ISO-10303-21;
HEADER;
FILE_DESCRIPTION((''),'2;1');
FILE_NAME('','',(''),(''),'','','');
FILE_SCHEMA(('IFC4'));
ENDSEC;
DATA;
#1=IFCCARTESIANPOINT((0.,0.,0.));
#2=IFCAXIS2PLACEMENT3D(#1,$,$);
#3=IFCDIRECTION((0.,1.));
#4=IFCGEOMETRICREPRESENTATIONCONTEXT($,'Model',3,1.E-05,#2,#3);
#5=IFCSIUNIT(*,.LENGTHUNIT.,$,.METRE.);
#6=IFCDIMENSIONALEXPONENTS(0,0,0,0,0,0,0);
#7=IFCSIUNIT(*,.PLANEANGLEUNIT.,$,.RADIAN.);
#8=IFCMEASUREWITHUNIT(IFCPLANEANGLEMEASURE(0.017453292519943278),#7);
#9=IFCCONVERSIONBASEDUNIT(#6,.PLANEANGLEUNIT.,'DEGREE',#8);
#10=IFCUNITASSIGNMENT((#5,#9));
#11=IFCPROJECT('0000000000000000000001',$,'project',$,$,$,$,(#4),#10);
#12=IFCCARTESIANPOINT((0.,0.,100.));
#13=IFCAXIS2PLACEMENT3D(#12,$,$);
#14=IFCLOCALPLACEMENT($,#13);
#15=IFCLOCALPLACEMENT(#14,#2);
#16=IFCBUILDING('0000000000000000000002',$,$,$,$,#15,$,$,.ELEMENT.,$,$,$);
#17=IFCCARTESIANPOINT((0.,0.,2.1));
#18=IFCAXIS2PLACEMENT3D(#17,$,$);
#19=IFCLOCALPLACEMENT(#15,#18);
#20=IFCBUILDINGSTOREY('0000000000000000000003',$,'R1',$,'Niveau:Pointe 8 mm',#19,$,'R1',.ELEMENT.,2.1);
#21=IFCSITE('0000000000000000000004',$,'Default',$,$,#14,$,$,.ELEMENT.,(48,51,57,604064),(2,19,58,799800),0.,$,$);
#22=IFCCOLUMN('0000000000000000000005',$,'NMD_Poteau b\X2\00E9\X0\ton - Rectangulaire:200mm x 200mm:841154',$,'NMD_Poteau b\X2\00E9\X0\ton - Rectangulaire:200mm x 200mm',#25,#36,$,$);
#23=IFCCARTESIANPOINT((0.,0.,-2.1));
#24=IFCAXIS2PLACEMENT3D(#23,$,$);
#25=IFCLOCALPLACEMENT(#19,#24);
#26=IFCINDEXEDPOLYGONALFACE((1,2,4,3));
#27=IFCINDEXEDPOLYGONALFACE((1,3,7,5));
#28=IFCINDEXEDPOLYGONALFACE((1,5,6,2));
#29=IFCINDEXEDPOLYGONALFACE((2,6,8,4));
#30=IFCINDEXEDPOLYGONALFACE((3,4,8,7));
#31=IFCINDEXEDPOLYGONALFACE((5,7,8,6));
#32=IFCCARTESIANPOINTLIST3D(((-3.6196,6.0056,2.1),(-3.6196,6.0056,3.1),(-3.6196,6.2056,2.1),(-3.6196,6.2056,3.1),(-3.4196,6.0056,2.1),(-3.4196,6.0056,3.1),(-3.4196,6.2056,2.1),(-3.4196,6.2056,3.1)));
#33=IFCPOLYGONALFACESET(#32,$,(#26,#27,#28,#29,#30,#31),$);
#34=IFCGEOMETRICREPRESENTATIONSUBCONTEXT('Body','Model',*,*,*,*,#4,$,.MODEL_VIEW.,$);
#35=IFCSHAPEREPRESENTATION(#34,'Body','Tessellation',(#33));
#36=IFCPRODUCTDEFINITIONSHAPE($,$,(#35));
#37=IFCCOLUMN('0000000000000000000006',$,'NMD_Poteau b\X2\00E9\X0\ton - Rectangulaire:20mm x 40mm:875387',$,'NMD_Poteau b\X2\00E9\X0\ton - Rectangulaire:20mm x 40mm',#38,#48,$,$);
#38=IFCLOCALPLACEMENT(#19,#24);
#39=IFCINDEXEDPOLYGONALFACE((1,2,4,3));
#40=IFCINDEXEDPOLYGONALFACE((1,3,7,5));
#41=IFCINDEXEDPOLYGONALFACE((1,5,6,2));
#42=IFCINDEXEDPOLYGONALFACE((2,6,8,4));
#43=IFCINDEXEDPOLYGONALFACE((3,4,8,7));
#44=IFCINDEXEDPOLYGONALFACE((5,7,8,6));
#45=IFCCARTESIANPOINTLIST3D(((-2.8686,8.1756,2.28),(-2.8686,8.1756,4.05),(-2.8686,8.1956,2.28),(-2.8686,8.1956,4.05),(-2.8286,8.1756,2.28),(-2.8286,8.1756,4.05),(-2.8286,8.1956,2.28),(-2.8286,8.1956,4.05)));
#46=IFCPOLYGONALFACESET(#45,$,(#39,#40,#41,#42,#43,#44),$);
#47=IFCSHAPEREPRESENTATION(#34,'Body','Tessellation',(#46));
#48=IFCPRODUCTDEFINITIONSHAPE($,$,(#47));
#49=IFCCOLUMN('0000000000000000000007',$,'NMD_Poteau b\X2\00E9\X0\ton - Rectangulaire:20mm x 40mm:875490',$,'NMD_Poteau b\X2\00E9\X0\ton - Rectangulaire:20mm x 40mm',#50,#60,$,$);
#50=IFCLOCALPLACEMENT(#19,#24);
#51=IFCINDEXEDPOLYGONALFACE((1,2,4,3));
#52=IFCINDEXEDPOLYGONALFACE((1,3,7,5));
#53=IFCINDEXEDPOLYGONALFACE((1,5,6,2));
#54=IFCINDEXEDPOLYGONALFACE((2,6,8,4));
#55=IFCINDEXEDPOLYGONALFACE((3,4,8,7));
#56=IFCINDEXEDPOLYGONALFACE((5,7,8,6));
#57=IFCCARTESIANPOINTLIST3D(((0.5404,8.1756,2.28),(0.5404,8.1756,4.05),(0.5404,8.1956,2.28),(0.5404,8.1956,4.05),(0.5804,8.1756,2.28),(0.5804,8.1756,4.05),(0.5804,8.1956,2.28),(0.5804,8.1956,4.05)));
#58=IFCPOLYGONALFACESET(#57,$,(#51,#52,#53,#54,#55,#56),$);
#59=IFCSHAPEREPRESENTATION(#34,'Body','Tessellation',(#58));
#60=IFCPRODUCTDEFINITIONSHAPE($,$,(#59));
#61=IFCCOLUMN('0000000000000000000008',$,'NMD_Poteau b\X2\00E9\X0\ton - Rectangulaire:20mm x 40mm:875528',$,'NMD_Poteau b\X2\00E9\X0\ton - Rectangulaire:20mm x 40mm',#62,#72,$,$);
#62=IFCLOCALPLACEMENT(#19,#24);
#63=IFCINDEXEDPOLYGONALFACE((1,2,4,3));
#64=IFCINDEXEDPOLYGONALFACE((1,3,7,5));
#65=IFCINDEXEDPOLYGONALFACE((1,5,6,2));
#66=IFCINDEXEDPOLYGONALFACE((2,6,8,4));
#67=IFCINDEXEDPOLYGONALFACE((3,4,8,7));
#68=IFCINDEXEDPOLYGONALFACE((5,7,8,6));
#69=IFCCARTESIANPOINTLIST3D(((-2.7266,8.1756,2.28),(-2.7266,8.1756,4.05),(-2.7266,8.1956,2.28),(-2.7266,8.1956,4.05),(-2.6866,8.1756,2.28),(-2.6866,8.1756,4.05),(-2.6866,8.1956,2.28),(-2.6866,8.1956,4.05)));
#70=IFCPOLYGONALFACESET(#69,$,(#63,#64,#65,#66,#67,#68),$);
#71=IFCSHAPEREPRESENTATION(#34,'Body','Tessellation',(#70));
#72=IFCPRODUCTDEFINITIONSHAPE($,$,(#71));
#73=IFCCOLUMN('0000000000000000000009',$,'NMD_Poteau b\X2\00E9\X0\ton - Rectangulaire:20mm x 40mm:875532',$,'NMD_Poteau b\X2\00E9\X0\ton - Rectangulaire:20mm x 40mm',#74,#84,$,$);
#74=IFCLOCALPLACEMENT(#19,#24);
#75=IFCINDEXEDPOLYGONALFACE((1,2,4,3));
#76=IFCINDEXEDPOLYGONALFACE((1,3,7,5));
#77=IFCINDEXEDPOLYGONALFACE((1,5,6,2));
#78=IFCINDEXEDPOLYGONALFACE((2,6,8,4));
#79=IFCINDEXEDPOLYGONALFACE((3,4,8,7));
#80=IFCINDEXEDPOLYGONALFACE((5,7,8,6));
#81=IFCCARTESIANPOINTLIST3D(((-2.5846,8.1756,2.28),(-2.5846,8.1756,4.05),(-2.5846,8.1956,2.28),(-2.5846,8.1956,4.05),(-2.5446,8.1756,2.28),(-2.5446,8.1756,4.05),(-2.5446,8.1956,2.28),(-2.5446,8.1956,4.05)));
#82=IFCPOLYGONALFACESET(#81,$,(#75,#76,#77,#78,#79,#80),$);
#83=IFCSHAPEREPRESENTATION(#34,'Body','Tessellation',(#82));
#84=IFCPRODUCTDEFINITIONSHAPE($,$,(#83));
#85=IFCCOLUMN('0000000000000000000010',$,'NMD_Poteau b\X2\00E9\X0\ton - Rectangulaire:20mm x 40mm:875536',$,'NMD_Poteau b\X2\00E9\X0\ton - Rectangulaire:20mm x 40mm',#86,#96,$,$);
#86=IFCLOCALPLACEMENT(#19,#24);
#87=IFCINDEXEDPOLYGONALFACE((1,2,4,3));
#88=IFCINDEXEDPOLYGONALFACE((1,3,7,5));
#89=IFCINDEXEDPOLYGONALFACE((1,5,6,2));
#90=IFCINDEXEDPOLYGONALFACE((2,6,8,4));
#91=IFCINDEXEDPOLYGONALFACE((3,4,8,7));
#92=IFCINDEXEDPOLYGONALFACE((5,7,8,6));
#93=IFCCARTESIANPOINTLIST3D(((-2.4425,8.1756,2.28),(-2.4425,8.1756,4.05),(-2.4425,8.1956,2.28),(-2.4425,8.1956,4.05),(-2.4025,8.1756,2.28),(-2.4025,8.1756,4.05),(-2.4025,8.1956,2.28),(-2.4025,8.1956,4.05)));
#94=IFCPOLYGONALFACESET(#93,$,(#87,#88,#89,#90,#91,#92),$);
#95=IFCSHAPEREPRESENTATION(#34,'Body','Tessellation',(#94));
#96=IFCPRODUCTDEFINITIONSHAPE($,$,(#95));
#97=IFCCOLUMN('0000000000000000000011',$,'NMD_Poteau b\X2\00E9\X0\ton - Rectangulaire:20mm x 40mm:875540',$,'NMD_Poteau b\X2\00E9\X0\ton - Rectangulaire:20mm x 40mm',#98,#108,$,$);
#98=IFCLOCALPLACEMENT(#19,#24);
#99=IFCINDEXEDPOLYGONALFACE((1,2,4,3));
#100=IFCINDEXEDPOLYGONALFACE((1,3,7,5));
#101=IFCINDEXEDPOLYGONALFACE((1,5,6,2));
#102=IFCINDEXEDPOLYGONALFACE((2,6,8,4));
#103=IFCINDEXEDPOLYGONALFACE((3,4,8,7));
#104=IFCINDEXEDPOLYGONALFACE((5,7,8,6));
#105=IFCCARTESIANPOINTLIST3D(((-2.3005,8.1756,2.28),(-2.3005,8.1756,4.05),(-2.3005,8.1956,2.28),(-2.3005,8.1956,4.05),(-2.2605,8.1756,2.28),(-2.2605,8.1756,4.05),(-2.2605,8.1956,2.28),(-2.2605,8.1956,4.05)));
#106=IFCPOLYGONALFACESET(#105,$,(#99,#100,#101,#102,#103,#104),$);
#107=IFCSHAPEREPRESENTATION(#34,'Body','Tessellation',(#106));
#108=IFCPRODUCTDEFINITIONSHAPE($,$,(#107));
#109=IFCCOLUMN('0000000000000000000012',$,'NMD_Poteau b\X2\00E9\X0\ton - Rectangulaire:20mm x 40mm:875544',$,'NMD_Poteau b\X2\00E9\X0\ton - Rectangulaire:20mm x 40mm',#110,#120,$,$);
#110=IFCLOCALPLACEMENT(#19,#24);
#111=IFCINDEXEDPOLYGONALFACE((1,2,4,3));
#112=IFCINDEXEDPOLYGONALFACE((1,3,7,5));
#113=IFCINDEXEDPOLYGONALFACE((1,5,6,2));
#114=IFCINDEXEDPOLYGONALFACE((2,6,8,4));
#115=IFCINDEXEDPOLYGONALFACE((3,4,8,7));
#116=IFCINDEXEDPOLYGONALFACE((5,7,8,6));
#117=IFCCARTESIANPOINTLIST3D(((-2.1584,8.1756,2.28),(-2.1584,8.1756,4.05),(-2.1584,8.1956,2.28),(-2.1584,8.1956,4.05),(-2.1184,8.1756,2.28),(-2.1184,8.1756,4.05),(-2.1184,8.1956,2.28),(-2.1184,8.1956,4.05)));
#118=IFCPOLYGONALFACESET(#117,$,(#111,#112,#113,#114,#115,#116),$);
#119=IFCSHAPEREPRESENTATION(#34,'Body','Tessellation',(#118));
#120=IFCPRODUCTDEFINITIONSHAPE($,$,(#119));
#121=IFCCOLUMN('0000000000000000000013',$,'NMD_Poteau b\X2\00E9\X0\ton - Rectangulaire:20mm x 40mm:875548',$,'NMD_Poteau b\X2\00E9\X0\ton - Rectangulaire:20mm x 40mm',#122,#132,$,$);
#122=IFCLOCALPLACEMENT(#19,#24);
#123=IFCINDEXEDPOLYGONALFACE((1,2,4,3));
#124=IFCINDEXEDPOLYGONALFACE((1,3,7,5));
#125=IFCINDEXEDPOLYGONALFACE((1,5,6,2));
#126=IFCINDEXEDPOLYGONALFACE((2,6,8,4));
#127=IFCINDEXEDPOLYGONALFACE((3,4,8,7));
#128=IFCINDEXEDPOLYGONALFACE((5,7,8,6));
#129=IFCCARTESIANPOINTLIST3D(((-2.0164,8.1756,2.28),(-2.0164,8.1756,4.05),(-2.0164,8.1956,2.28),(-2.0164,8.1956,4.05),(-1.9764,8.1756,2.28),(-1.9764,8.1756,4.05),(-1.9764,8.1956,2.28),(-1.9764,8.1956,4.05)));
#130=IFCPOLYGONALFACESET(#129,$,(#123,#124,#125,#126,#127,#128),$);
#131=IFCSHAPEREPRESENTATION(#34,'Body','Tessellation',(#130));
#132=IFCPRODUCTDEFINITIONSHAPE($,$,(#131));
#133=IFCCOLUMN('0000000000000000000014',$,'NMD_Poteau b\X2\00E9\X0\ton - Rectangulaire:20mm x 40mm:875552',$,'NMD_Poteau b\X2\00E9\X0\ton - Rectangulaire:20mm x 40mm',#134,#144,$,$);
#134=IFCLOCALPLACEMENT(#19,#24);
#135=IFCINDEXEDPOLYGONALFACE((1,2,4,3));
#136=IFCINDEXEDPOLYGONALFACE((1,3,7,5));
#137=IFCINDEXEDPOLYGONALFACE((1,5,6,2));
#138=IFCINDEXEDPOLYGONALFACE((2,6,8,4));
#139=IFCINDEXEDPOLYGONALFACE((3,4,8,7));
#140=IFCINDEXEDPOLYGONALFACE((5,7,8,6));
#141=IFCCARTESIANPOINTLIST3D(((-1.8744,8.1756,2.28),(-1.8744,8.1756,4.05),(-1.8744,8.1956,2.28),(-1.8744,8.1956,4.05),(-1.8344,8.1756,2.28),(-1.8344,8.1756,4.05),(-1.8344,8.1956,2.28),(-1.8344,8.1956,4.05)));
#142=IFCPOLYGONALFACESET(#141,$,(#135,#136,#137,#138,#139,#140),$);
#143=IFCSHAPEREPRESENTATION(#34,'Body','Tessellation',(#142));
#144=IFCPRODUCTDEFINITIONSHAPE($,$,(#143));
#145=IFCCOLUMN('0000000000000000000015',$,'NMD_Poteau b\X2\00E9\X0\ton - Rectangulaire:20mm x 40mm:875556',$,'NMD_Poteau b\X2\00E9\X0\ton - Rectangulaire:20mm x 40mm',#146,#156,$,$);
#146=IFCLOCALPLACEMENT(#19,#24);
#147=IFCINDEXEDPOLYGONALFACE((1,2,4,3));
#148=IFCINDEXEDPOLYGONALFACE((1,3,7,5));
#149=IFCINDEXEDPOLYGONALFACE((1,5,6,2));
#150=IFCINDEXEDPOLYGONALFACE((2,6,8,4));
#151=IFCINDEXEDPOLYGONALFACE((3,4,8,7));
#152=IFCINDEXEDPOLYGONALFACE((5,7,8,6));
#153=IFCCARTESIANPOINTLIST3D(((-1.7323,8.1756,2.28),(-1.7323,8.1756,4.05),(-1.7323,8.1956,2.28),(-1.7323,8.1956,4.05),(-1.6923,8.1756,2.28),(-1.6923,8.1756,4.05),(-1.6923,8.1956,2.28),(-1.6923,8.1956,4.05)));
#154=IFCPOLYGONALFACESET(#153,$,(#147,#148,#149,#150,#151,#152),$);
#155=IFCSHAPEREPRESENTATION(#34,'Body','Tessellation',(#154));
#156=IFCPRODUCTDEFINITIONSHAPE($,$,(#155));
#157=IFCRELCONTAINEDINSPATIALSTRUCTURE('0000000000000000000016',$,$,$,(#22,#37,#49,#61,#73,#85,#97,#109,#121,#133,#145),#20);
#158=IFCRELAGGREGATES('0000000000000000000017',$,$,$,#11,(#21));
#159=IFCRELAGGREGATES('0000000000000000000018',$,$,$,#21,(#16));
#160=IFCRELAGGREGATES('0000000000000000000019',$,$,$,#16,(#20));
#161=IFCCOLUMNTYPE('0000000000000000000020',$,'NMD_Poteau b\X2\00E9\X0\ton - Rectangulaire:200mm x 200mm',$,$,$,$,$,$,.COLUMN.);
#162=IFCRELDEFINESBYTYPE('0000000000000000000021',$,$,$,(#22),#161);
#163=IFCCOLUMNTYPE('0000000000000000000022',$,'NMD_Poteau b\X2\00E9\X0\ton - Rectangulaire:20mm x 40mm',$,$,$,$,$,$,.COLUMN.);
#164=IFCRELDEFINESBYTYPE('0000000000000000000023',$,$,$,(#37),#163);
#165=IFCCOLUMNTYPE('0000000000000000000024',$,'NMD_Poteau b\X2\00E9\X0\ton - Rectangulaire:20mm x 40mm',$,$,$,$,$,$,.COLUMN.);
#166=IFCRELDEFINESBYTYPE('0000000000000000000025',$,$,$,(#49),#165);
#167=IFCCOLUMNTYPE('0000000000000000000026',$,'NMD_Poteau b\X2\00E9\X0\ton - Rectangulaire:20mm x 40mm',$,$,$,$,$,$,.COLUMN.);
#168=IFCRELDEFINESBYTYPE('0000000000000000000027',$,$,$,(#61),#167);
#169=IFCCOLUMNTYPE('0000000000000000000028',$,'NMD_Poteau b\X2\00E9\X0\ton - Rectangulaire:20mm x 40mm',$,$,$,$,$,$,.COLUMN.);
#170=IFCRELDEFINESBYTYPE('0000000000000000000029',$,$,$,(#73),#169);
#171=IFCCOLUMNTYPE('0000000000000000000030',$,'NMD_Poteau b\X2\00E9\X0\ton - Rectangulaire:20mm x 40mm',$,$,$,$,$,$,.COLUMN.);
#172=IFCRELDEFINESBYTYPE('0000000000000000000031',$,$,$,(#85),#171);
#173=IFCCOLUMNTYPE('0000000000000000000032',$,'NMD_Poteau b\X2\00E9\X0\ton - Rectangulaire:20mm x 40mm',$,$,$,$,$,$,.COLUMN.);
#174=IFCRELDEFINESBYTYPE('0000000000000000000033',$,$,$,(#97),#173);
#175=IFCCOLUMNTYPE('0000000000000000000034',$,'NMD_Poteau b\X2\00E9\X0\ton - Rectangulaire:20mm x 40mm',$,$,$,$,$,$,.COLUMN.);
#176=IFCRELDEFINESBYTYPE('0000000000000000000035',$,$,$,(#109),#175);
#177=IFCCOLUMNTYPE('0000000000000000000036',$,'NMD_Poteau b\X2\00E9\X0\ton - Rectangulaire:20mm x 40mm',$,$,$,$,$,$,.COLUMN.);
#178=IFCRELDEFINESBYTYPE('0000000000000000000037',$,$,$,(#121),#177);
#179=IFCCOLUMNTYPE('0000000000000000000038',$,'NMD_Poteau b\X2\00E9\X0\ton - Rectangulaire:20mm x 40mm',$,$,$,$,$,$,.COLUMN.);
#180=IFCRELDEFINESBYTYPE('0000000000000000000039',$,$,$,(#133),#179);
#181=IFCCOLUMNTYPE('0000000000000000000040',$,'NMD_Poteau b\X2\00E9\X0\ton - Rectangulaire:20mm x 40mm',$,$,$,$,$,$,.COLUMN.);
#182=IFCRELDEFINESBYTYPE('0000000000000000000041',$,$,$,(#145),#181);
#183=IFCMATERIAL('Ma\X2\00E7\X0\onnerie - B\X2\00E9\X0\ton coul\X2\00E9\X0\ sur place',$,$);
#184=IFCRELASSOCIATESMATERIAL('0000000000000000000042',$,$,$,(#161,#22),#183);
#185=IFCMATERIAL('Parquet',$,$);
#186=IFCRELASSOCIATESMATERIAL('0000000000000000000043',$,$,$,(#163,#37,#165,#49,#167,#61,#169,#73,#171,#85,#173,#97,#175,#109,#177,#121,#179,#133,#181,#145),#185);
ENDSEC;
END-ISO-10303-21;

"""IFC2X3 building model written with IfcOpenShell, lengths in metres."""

from ifc_helpers import new_model, entity, si_unit, converted_unit, direction, frame, frame_2d, origin, origin_2d_with_axis, place, context, subcontext, project, spatial, rectangle, extrude, source, transform, mapped, material, type_object, type_shapes, element, save


model = new_model("IFC2X3")

# Units and contexts
model_context = context("Model", 3, precision=1e-05, world=origin(), true_north=direction((0.0, 1.0)))
body_context = subcontext(model_context, "Body", "Model", "MODEL_VIEW")
ifc_project = project(units=[si_unit("LENGTHUNIT", "METRE"), converted_unit("PLANEANGLEUNIT", "DEGREE", entity("IfcPlaneAngleMeasure", 0.017453292519943278), si_unit("PLANEANGLEUNIT", "RADIAN"), dimensions=[0, 0, 0, 0, 0, 0, 0])], contexts=[model_context])

# Site, building, storey
site_placement = place(None, frame((0.0, 0.0, 100.0)))
site = spatial("IfcSite", under=ifc_project, at=site_placement, Name="Default", CompositionType="ELEMENT", RefLatitude=(48, 51, 57, 604064), RefLongitude=(2, 19, 58, 799800), RefElevation=0.0)
building_placement = place(site_placement, origin())
building = spatial("IfcBuilding", under=site, at=building_placement, CompositionType="ELEMENT")
storey_placement = place(building_placement, frame((0.0, 0.0, 2.1)))
storey = spatial("IfcBuildingStorey", under=building, at=storey_placement, Name="R1", ObjectType="Niveau:Pointe 8 mm", LongName="R1", CompositionType="ELEMENT", Elevation=2.1)

# Columns
ifc_material_1 = material(Name="Maçonnerie - Béton coulé sur place")
column_type_1 = type_object("IfcColumnType", Name="NMD_Poteau béton - Rectangulaire:200mm x 200mm", PredefinedType="COLUMN", material=ifc_material_1)
shared_shape_1 = source(origin(), body_context, "Body", "SweptSolid", [
    extrude(rectangle(XDim=0.2, YDim=0.2, at=origin_2d_with_axis()), frame((-3.5196, 6.1056, 2.1), z_axis=(0.0, 0.0, 1.0), x_axis=(-1.0, 0.0, 0.0)), (0.0, 0.0, 1.0), 1.0),
])
type_shapes(column_type_1, [shared_shape_1])
column_1_placement = place(storey_placement, frame((0.0, 0.0, -2.1)))
element("IfcColumn", 1, at=column_1_placement, inside=storey, type_object=column_type_1, material=ifc_material_1, Name="NMD_Poteau béton - Rectangulaire:200mm x 200mm:841154", ObjectType="NMD_Poteau béton - Rectangulaire:200mm x 200mm", context=body_context, shape_type="MappedRepresentation", body=[
    mapped(shared_shape_1, transform((0.0, 0.0, 0.0), scale=1.0)),
])
ifc_material_2 = material(Name="Parquet")
column_type_2 = type_object("IfcColumnType", Name="NMD_Poteau béton - Rectangulaire:20mm x 40mm", PredefinedType="COLUMN", material=ifc_material_2)
shared_shape_2 = source(origin(), body_context, "Body", "SweptSolid", [
    extrude(rectangle(XDim=0.02, YDim=0.04, at=frame_2d((0.0, 0.0), x_axis=(1.0, 0.0))), frame((-2.8486, 8.1856, 2.28), z_axis=(0.0, 0.0, 1.0), x_axis=(0.0, -1.0, 0.0)), (0.0, 0.0, 1.0), 1.77),
])
type_shapes(column_type_2, [shared_shape_2])
column_2_placement = place(storey_placement, frame((0.0, 0.0, -2.1)))
element("IfcColumn", 2, at=column_2_placement, inside=storey, type_object=column_type_2, material=ifc_material_2, Name="NMD_Poteau béton - Rectangulaire:20mm x 40mm:875387", ObjectType="NMD_Poteau béton - Rectangulaire:20mm x 40mm", context=body_context, shape_type="MappedRepresentation", body=[
    mapped(shared_shape_2, transform((0.0, 0.0, 0.0), scale=1.0)),
])
column_type_3 = type_object("IfcColumnType", Name="NMD_Poteau béton - Rectangulaire:20mm x 40mm", PredefinedType="COLUMN", material=ifc_material_2)
shared_shape_3 = source(origin(), body_context, "Body", "SweptSolid", [
    extrude(rectangle(XDim=0.02, YDim=0.04, at=frame_2d((0.0, 0.0), x_axis=(1.0, 0.0))), frame((0.5604, 8.1856, 2.28), z_axis=(0.0, 0.0, 1.0), x_axis=(0.0, -1.0, 0.0)), (0.0, 0.0, 1.0), 1.77),
])
type_shapes(column_type_3, [shared_shape_3])
column_3_placement = place(storey_placement, frame((0.0, 0.0, -2.1)))
element("IfcColumn", 3, at=column_3_placement, inside=storey, type_object=column_type_3, material=ifc_material_2, Name="NMD_Poteau béton - Rectangulaire:20mm x 40mm:875490", ObjectType="NMD_Poteau béton - Rectangulaire:20mm x 40mm", context=body_context, shape_type="MappedRepresentation", body=[
    mapped(shared_shape_3, transform((0.0, 0.0, 0.0), scale=1.0)),
])
column_type_4 = type_object("IfcColumnType", Name="NMD_Poteau béton - Rectangulaire:20mm x 40mm", PredefinedType="COLUMN", material=ifc_material_2)
shared_shape_4 = source(origin(), body_context, "Body", "SweptSolid", [
    extrude(rectangle(XDim=0.02, YDim=0.04, at=frame_2d((0.0, 0.0), x_axis=(1.0, 0.0))), frame((-2.7066, 8.1856, 2.28), z_axis=(0.0, 0.0, 1.0), x_axis=(0.0, -1.0, 0.0)), (0.0, 0.0, 1.0), 1.77),
])
type_shapes(column_type_4, [shared_shape_4])
column_4_placement = place(storey_placement, frame((0.0, 0.0, -2.1)))
element("IfcColumn", 4, at=column_4_placement, inside=storey, type_object=column_type_4, material=ifc_material_2, Name="NMD_Poteau béton - Rectangulaire:20mm x 40mm:875528", ObjectType="NMD_Poteau béton - Rectangulaire:20mm x 40mm", context=body_context, shape_type="MappedRepresentation", body=[
    mapped(shared_shape_4, transform((0.0, 0.0, 0.0), scale=1.0)),
])
column_type_5 = type_object("IfcColumnType", Name="NMD_Poteau béton - Rectangulaire:20mm x 40mm", PredefinedType="COLUMN", material=ifc_material_2)
shared_shape_5 = source(origin(), body_context, "Body", "SweptSolid", [
    extrude(rectangle(XDim=0.02, YDim=0.04, at=frame_2d((0.0, 0.0), x_axis=(1.0, 0.0))), frame((-2.5646, 8.1856, 2.28), z_axis=(0.0, 0.0, 1.0), x_axis=(0.0, -1.0, 0.0)), (0.0, 0.0, 1.0), 1.77),
])
type_shapes(column_type_5, [shared_shape_5])
column_5_placement = place(storey_placement, frame((0.0, 0.0, -2.1)))
element("IfcColumn", 5, at=column_5_placement, inside=storey, type_object=column_type_5, material=ifc_material_2, Name="NMD_Poteau béton - Rectangulaire:20mm x 40mm:875532", ObjectType="NMD_Poteau béton - Rectangulaire:20mm x 40mm", context=body_context, shape_type="MappedRepresentation", body=[
    mapped(shared_shape_5, transform((0.0, 0.0, 0.0), scale=1.0)),
])
column_type_6 = type_object("IfcColumnType", Name="NMD_Poteau béton - Rectangulaire:20mm x 40mm", PredefinedType="COLUMN", material=ifc_material_2)
shared_shape_6 = source(origin(), body_context, "Body", "SweptSolid", [
    extrude(rectangle(XDim=0.02, YDim=0.04, at=frame_2d((0.0, 0.0), x_axis=(1.0, 0.0))), frame((-2.4225, 8.1856, 2.28), z_axis=(0.0, 0.0, 1.0), x_axis=(0.0, -1.0, 0.0)), (0.0, 0.0, 1.0), 1.77),
])
type_shapes(column_type_6, [shared_shape_6])
column_6_placement = place(storey_placement, frame((0.0, 0.0, -2.1)))
element("IfcColumn", 6, at=column_6_placement, inside=storey, type_object=column_type_6, material=ifc_material_2, Name="NMD_Poteau béton - Rectangulaire:20mm x 40mm:875536", ObjectType="NMD_Poteau béton - Rectangulaire:20mm x 40mm", context=body_context, shape_type="MappedRepresentation", body=[
    mapped(shared_shape_6, transform((0.0, 0.0, 0.0), scale=1.0)),
])
column_type_7 = type_object("IfcColumnType", Name="NMD_Poteau béton - Rectangulaire:20mm x 40mm", PredefinedType="COLUMN", material=ifc_material_2)
shared_shape_7 = source(origin(), body_context, "Body", "SweptSolid", [
    extrude(rectangle(XDim=0.02, YDim=0.04, at=origin_2d_with_axis()), frame((-2.2805, 8.1856, 2.28), z_axis=(0.0, 0.0, 1.0), x_axis=(0.0, -1.0, 0.0)), (0.0, 0.0, 1.0), 1.77),
])
type_shapes(column_type_7, [shared_shape_7])
column_7_placement = place(storey_placement, frame((0.0, 0.0, -2.1)))
element("IfcColumn", 7, at=column_7_placement, inside=storey, type_object=column_type_7, material=ifc_material_2, Name="NMD_Poteau béton - Rectangulaire:20mm x 40mm:875540", ObjectType="NMD_Poteau béton - Rectangulaire:20mm x 40mm", context=body_context, shape_type="MappedRepresentation", body=[
    mapped(shared_shape_7, transform((0.0, 0.0, 0.0), scale=1.0)),
])
column_type_8 = type_object("IfcColumnType", Name="NMD_Poteau béton - Rectangulaire:20mm x 40mm", PredefinedType="COLUMN", material=ifc_material_2)
shared_shape_8 = source(origin(), body_context, "Body", "SweptSolid", [
    extrude(rectangle(XDim=0.02, YDim=0.04, at=origin_2d_with_axis()), frame((-2.1384, 8.1856, 2.28), z_axis=(0.0, 0.0, 1.0), x_axis=(0.0, -1.0, 0.0)), (0.0, 0.0, 1.0), 1.77),
])
type_shapes(column_type_8, [shared_shape_8])
column_8_placement = place(storey_placement, frame((0.0, 0.0, -2.1)))
element("IfcColumn", 8, at=column_8_placement, inside=storey, type_object=column_type_8, material=ifc_material_2, Name="NMD_Poteau béton - Rectangulaire:20mm x 40mm:875544", ObjectType="NMD_Poteau béton - Rectangulaire:20mm x 40mm", context=body_context, shape_type="MappedRepresentation", body=[
    mapped(shared_shape_8, transform((0.0, 0.0, 0.0), scale=1.0)),
])
column_type_9 = type_object("IfcColumnType", Name="NMD_Poteau béton - Rectangulaire:20mm x 40mm", PredefinedType="COLUMN", material=ifc_material_2)
shared_shape_9 = source(origin(), body_context, "Body", "SweptSolid", [
    extrude(rectangle(XDim=0.02, YDim=0.04, at=origin_2d_with_axis()), frame((-1.9964, 8.1856, 2.28), z_axis=(0.0, 0.0, 1.0), x_axis=(0.0, -1.0, 0.0)), (0.0, 0.0, 1.0), 1.77),
])
type_shapes(column_type_9, [shared_shape_9])
column_9_placement = place(storey_placement, frame((0.0, 0.0, -2.1)))
element("IfcColumn", 9, at=column_9_placement, inside=storey, type_object=column_type_9, material=ifc_material_2, Name="NMD_Poteau béton - Rectangulaire:20mm x 40mm:875548", ObjectType="NMD_Poteau béton - Rectangulaire:20mm x 40mm", context=body_context, shape_type="MappedRepresentation", body=[
    mapped(shared_shape_9, transform((0.0, 0.0, 0.0), scale=1.0)),
])
column_type_10 = type_object("IfcColumnType", Name="NMD_Poteau béton - Rectangulaire:20mm x 40mm", PredefinedType="COLUMN", material=ifc_material_2)
shared_shape_10 = source(origin(), body_context, "Body", "SweptSolid", [
    extrude(rectangle(XDim=0.02, YDim=0.04, at=origin_2d_with_axis()), frame((-1.8544, 8.1856, 2.28), z_axis=(0.0, 0.0, 1.0), x_axis=(0.0, -1.0, 0.0)), (0.0, 0.0, 1.0), 1.77),
])
type_shapes(column_type_10, [shared_shape_10])
column_10_placement = place(storey_placement, frame((0.0, 0.0, -2.1)))
element("IfcColumn", 10, at=column_10_placement, inside=storey, type_object=column_type_10, material=ifc_material_2, Name="NMD_Poteau béton - Rectangulaire:20mm x 40mm:875552", ObjectType="NMD_Poteau béton - Rectangulaire:20mm x 40mm", context=body_context, shape_type="MappedRepresentation", body=[
    mapped(shared_shape_10, transform((0.0, 0.0, 0.0), scale=1.0)),
])
column_type_11 = type_object("IfcColumnType", Name="NMD_Poteau béton - Rectangulaire:20mm x 40mm", PredefinedType="COLUMN", material=ifc_material_2)
shared_shape_11 = source(origin(), body_context, "Body", "SweptSolid", [
    extrude(rectangle(XDim=0.02, YDim=0.04, at=origin_2d_with_axis()), frame((-1.7123, 8.1856, 2.28), z_axis=(0.0, 0.0, 1.0), x_axis=(0.0, -1.0, 0.0)), (0.0, 0.0, 1.0), 1.77),
])
type_shapes(column_type_11, [shared_shape_11])
column_11_placement = place(storey_placement, frame((0.0, 0.0, -2.1)))
element("IfcColumn", 11, at=column_11_placement, inside=storey, type_object=column_type_11, material=ifc_material_2, Name="NMD_Poteau béton - Rectangulaire:20mm x 40mm:875556", ObjectType="NMD_Poteau béton - Rectangulaire:20mm x 40mm", context=body_context, shape_type="MappedRepresentation", body=[
    mapped(shared_shape_11, transform((0.0, 0.0, 0.0), scale=1.0)),
])

save(model, "model.ifc")
